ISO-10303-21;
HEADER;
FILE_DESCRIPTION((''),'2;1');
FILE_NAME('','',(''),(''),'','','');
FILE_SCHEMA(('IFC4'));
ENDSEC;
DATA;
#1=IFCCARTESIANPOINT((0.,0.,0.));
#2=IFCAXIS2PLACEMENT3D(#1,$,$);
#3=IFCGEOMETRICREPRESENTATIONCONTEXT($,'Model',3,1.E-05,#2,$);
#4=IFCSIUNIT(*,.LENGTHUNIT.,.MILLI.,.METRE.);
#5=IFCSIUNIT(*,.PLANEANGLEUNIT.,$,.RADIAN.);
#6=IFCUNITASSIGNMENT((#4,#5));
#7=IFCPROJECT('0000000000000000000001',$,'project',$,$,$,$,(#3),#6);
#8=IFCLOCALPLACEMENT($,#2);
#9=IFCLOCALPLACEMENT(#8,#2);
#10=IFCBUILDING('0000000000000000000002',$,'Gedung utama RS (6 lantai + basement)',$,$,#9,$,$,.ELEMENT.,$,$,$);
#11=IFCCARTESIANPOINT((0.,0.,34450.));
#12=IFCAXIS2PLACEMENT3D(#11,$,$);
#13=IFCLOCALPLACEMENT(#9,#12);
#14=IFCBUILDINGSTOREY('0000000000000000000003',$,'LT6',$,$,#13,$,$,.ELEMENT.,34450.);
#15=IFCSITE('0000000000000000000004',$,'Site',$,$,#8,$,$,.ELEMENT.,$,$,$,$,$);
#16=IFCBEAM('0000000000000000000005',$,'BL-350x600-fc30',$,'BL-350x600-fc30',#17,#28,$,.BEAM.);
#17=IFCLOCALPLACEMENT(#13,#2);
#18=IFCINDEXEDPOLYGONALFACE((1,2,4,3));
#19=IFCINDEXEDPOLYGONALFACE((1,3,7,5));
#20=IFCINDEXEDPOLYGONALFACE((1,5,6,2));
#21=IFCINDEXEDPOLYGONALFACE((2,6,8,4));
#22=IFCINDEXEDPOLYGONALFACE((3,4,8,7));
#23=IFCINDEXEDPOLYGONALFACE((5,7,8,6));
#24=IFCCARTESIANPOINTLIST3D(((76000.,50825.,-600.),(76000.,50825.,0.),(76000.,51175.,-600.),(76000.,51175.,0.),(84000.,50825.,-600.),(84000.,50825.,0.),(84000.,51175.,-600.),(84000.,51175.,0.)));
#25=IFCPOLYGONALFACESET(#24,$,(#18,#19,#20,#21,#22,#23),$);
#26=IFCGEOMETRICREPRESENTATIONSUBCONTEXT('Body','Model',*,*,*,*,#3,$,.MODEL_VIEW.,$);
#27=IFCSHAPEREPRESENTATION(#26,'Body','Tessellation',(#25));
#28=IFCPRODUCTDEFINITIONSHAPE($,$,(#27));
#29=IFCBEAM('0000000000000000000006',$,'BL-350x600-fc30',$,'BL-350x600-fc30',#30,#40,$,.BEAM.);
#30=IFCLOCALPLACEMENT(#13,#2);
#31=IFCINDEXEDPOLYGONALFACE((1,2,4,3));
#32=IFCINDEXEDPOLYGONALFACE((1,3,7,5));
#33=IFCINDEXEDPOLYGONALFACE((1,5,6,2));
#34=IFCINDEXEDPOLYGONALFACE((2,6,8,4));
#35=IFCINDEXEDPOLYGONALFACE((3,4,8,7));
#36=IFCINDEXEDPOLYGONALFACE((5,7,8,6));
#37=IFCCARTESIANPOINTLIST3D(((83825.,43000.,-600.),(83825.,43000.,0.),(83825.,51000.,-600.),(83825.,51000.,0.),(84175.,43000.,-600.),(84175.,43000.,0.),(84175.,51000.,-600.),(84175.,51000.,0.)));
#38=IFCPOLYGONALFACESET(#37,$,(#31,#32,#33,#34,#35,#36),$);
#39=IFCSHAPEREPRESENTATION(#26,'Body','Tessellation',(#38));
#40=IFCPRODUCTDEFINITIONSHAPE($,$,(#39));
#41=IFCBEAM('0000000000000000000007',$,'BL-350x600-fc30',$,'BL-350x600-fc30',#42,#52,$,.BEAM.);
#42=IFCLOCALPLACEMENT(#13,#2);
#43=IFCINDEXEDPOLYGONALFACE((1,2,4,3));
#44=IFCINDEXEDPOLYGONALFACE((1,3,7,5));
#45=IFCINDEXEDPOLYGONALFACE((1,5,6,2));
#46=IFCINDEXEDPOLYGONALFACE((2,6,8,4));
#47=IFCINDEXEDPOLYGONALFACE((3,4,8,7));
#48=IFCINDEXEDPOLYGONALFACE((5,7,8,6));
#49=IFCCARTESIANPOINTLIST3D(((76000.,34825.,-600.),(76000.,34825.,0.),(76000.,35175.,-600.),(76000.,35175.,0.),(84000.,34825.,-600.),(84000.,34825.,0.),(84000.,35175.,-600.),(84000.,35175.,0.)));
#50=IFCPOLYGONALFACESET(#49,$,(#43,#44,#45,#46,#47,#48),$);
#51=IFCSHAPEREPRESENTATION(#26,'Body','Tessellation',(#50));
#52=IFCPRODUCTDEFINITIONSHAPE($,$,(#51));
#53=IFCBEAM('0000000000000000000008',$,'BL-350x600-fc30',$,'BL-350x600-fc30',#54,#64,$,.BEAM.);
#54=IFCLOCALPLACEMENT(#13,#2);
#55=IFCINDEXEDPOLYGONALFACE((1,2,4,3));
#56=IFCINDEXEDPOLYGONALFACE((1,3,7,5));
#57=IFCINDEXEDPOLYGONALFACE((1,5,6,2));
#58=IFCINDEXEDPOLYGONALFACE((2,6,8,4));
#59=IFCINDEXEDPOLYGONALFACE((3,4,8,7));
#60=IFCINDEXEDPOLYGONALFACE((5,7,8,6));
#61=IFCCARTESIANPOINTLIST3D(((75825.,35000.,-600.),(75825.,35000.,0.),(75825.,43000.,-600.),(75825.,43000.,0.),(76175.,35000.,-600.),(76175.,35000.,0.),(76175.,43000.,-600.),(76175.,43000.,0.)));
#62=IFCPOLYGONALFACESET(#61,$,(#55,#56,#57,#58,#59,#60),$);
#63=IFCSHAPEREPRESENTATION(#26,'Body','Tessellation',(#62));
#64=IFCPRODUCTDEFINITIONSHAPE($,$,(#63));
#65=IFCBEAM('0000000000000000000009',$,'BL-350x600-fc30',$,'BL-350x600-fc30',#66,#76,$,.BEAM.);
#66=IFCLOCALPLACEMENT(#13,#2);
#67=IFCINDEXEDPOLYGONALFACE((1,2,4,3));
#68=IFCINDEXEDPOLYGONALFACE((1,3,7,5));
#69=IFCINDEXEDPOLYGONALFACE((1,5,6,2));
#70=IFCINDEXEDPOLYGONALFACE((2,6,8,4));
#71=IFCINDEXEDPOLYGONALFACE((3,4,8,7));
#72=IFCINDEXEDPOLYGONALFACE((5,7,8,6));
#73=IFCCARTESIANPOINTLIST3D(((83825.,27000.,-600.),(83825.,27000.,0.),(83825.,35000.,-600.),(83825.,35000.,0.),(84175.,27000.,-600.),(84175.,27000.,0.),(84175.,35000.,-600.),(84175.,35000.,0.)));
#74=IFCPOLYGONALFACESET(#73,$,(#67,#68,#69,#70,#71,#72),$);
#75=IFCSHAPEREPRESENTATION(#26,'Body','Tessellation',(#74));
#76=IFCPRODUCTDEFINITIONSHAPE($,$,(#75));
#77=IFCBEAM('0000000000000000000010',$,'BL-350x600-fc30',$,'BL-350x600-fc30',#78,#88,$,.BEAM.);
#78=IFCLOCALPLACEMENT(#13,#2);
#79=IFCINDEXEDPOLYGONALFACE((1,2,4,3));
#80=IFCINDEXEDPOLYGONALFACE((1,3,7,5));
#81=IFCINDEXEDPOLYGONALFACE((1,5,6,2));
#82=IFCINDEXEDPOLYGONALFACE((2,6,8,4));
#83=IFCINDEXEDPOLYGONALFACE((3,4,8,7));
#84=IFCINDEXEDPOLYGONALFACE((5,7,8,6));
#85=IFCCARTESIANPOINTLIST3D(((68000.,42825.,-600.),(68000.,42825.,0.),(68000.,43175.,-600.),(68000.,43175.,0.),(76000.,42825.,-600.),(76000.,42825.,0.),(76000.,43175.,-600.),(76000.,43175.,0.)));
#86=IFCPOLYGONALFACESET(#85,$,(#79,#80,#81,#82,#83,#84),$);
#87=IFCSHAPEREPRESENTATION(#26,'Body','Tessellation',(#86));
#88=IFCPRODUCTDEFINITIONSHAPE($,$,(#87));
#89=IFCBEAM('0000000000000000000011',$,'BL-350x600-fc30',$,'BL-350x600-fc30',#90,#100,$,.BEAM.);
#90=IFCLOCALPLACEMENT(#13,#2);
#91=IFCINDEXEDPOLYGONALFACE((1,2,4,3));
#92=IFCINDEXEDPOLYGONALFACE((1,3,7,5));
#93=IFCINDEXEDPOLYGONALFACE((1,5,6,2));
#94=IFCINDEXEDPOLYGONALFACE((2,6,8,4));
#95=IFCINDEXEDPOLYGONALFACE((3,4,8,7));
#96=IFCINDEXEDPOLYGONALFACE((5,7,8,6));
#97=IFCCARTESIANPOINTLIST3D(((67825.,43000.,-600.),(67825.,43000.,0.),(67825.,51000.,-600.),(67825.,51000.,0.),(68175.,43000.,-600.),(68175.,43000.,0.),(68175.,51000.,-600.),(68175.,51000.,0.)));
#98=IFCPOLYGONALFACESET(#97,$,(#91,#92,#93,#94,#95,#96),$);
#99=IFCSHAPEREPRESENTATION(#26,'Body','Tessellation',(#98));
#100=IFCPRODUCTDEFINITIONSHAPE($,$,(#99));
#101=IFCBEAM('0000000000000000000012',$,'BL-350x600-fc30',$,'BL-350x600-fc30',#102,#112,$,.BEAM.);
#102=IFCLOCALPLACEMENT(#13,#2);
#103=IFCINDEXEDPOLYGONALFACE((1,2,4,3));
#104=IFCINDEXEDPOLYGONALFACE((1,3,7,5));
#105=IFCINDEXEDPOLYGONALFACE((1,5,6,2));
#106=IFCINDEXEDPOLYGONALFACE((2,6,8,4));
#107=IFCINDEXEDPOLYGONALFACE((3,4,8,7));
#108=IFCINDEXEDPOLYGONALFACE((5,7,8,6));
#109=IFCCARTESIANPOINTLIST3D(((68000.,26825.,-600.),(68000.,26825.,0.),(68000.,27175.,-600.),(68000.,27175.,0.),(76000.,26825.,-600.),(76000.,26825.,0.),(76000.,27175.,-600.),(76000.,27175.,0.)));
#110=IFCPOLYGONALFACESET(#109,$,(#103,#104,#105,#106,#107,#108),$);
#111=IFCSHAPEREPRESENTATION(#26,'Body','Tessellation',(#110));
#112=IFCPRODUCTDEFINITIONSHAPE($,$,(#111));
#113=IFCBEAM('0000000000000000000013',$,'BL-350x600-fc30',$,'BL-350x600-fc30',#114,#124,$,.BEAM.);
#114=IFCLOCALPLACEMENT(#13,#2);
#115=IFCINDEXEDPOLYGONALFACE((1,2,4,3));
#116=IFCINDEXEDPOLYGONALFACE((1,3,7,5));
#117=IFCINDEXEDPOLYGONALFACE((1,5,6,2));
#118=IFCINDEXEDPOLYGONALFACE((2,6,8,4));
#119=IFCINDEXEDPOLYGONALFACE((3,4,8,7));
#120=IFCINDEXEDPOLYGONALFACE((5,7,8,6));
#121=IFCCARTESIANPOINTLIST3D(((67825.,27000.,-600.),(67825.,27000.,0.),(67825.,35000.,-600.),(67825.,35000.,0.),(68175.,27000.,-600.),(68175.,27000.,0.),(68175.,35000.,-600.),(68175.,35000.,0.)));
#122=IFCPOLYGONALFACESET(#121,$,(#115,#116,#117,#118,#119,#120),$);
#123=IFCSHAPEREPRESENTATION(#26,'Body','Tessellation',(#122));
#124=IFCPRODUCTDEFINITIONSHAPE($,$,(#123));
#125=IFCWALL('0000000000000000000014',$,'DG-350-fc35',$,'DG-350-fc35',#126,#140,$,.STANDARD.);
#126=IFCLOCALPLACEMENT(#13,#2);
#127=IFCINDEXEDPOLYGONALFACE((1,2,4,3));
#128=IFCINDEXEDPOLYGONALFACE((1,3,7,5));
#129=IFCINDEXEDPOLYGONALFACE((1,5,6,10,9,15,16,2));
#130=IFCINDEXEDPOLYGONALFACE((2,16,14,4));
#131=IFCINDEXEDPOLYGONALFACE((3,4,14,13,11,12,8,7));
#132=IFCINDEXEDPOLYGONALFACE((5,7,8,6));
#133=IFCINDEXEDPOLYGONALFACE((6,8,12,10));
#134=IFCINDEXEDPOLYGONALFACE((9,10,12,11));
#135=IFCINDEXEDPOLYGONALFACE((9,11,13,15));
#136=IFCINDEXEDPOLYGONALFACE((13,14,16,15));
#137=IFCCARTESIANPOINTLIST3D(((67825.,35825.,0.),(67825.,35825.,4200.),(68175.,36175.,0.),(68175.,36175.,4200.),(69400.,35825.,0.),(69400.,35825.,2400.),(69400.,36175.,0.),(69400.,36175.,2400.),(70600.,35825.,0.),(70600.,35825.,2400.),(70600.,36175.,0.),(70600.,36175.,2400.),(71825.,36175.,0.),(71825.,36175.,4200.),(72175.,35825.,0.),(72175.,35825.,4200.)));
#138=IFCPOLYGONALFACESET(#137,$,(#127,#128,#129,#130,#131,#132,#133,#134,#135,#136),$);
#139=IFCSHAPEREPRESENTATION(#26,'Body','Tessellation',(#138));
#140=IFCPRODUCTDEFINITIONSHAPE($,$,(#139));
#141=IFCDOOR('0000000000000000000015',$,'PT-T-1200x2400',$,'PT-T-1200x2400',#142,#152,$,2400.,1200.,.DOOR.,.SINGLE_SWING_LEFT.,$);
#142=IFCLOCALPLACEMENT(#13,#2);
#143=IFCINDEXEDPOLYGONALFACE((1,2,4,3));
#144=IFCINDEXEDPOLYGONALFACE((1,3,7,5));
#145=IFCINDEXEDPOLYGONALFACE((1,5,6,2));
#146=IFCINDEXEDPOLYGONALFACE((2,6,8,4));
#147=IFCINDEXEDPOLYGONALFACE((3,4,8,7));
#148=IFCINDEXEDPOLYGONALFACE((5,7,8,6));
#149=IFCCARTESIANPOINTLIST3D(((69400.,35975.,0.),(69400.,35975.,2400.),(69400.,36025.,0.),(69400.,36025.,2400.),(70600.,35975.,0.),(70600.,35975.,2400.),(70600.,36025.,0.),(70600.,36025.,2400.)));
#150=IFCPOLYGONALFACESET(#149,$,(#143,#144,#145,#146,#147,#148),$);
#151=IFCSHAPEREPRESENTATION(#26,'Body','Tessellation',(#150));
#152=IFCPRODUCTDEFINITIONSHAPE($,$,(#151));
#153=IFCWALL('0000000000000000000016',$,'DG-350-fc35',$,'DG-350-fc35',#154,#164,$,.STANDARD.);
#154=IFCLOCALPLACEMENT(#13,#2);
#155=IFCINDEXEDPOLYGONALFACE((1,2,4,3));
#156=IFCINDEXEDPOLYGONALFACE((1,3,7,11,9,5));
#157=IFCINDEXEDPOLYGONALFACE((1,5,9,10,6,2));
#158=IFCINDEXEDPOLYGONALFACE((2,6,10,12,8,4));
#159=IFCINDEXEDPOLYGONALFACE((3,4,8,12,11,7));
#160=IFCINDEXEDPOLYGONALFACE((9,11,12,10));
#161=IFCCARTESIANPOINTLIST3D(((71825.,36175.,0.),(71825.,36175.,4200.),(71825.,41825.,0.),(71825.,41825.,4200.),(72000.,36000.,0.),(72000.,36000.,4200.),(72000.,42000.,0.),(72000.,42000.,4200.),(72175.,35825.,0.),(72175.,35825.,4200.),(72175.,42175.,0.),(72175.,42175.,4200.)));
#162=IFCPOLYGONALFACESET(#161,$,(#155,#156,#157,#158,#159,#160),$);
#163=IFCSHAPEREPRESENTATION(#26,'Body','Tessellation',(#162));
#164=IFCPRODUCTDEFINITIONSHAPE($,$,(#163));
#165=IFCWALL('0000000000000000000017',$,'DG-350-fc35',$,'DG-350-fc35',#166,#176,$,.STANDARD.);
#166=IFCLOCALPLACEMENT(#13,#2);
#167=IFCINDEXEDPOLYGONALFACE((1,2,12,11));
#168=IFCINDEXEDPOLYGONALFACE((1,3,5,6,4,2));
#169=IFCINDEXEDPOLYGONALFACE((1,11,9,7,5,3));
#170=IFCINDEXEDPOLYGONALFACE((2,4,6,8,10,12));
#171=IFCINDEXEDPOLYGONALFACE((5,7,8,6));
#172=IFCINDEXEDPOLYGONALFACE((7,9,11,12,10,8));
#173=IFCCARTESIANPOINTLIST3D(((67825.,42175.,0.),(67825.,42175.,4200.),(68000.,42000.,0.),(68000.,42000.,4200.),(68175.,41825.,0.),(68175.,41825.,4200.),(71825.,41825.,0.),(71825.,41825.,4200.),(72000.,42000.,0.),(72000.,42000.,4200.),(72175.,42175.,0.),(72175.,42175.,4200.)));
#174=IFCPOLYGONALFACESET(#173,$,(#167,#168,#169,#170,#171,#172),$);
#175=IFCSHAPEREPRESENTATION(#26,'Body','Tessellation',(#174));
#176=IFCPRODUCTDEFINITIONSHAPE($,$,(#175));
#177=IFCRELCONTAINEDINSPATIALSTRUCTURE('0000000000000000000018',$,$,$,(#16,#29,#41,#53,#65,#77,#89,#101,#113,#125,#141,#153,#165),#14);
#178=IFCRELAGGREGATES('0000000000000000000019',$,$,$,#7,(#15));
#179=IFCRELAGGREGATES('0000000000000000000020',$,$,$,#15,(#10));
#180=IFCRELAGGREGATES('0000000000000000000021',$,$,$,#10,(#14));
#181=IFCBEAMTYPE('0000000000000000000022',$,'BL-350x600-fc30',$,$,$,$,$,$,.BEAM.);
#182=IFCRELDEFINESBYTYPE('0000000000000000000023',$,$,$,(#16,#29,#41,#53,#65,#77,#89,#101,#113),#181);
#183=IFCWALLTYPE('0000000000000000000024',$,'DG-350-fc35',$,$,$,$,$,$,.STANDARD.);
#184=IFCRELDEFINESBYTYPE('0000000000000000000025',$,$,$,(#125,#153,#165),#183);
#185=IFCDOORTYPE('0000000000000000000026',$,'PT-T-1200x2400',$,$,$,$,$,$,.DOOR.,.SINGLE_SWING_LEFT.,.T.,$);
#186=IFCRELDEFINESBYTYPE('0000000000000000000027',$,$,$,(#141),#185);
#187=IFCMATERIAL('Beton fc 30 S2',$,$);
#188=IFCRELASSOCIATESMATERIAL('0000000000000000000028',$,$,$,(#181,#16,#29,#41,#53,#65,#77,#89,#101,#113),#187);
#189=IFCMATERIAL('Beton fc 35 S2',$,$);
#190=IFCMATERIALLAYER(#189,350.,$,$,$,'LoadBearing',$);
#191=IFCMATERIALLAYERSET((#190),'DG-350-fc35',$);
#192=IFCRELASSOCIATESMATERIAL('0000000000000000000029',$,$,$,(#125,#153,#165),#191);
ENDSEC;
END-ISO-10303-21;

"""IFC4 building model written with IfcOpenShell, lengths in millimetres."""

from ifc_helpers import new_model, si_unit, frame, frame_2d, origin, origin_2d, place, context, subcontext, project, spatial, polyline, rectangle, outline, extrude, material, layer, layer_set, layer_usage, material_profile, profile_set, profile_usage, type_object, element, fill, save


model = new_model("IFC4")

# Units and contexts
model_context = context("Model", 3, precision=1e-05, world=origin())
body_context = subcontext(model_context, "Body", "Model", "MODEL_VIEW")
ifc_project = project(units=[si_unit("LENGTHUNIT", "METRE", prefix="MILLI"), si_unit("PLANEANGLEUNIT", "RADIAN")], contexts=[model_context])

# Site, building, storey
site_placement = place(None, origin())
site = spatial("IfcSite", under=ifc_project, at=site_placement, Name="Site", CompositionType="ELEMENT")
building_placement = place(site_placement, origin())
building = spatial("IfcBuilding", under=site, at=building_placement, Name="Gedung utama RS (6 lantai + basement)", CompositionType="ELEMENT")
storey_placement = place(building_placement, frame((0.0, 0.0, 34450.0)))
storey = spatial("IfcBuildingStorey", under=building, at=storey_placement, Name="LT6", CompositionType="ELEMENT", Elevation=34450.0)

# Beams
ifc_material_1 = material(Name="Beton fc 30 S2")
ifc_material_profile_1 = material_profile(ifc_material_1, rectangle(XDim=350.0, YDim=600.0, at=origin_2d()), Name="BL-350x600-fc30")
ifc_profile_set_1 = profile_set([ifc_material_profile_1], Name="BL-350x600-fc30")
ifc_profile_usage_1 = profile_usage(ifc_profile_set_1, cardinal=8)
beam_type = type_object("IfcBeamType", Name="BL-350x600-fc30", PredefinedType="BEAM", material=ifc_profile_set_1)
beam_1_placement = place(storey_placement, frame((76000.0, 51000.0, -300.0)))
element("IfcBeam", 1, at=beam_1_placement, inside=storey, type_object=beam_type, material=ifc_profile_usage_1, Name="BL-350x600-fc30", ObjectType="BL-350x600-fc30", PredefinedType="BEAM", context=body_context, shape_type="SweptSolid", body=[
    extrude(rectangle(XDim=350.0, YDim=600.0, at=origin_2d()), frame((0.0, 0.0, 0.0), z_axis=(1.0, 0.0, 0.0), x_axis=(0.0, 1.0, 0.0)), (0.0, 0.0, 1.0), 8000.0),
])
beam_2_placement = place(storey_placement, frame((84000.0, 43000.0, -300.0)))
element("IfcBeam", 2, at=beam_2_placement, inside=storey, type_object=beam_type, material=ifc_profile_usage_1, Name="BL-350x600-fc30", ObjectType="BL-350x600-fc30", PredefinedType="BEAM", context=body_context, shape_type="SweptSolid", body=[
    extrude(rectangle(XDim=350.0, YDim=600.0, at=origin_2d()), frame((0.0, 0.0, 0.0), z_axis=(0.0, 1.0, 0.0), x_axis=(-1.0, 0.0, 0.0)), (0.0, 0.0, 1.0), 8000.0),
])
beam_3_placement = place(storey_placement, frame((76000.0, 35000.0, -300.0)))
element("IfcBeam", 3, at=beam_3_placement, inside=storey, type_object=beam_type, material=ifc_profile_usage_1, Name="BL-350x600-fc30", ObjectType="BL-350x600-fc30", PredefinedType="BEAM", context=body_context, shape_type="SweptSolid", body=[
    extrude(rectangle(XDim=350.0, YDim=600.0, at=origin_2d()), frame((0.0, 0.0, 0.0), z_axis=(1.0, 0.0, 0.0), x_axis=(0.0, 1.0, 0.0)), (0.0, 0.0, 1.0), 8000.0),
])
for number, where, name in (
    (4, (76000.0, 35000.0, -300.0), "BL-350x600-fc30"),
    (5, (84000.0, 27000.0, -300.0), "BL-350x600-fc30"),
):
    element("IfcBeam", number, at=place(storey_placement, frame(where)), inside=storey, type_object=beam_type, material=ifc_profile_usage_1, Name=name, ObjectType="BL-350x600-fc30", PredefinedType="BEAM", context=body_context, shape_type="SweptSolid", body=[
        extrude(rectangle(XDim=350.0, YDim=600.0, at=origin_2d()), frame((0.0, 0.0, 0.0), z_axis=(0.0, 1.0, 0.0), x_axis=(-1.0, 0.0, 0.0)), (0.0, 0.0, 1.0), 8000.0),
    ])
beam_4_placement = place(storey_placement, frame((68000.0, 43000.0, -300.0)))
element("IfcBeam", 6, at=beam_4_placement, inside=storey, type_object=beam_type, material=ifc_profile_usage_1, Name="BL-350x600-fc30", ObjectType="BL-350x600-fc30", PredefinedType="BEAM", context=body_context, shape_type="SweptSolid", body=[
    extrude(rectangle(XDim=350.0, YDim=600.0, at=origin_2d()), frame((0.0, 0.0, 0.0), z_axis=(1.0, 0.0, 0.0), x_axis=(0.0, 1.0, 0.0)), (0.0, 0.0, 1.0), 8000.0),
])
beam_5_placement = place(storey_placement, frame((68000.0, 43000.0, -300.0)))
element("IfcBeam", 7, at=beam_5_placement, inside=storey, type_object=beam_type, material=ifc_profile_usage_1, Name="BL-350x600-fc30", ObjectType="BL-350x600-fc30", PredefinedType="BEAM", context=body_context, shape_type="SweptSolid", body=[
    extrude(rectangle(XDim=350.0, YDim=600.0, at=origin_2d()), frame((0.0, 0.0, 0.0), z_axis=(0.0, 1.0, 0.0), x_axis=(-1.0, 0.0, 0.0)), (0.0, 0.0, 1.0), 8000.0),
])
beam_6_placement = place(storey_placement, frame((68000.0, 27000.0, -300.0)))
element("IfcBeam", 8, at=beam_6_placement, inside=storey, type_object=beam_type, material=ifc_profile_usage_1, Name="BL-350x600-fc30", ObjectType="BL-350x600-fc30", PredefinedType="BEAM", context=body_context, shape_type="SweptSolid", body=[
    extrude(rectangle(XDim=350.0, YDim=600.0, at=origin_2d()), frame((0.0, 0.0, 0.0), z_axis=(1.0, 0.0, 0.0), x_axis=(0.0, 1.0, 0.0)), (0.0, 0.0, 1.0), 8000.0),
])
beam_7_placement = place(storey_placement, frame((68000.0, 27000.0, -300.0)))
element("IfcBeam", 9, at=beam_7_placement, inside=storey, type_object=beam_type, material=ifc_profile_usage_1, Name="BL-350x600-fc30", ObjectType="BL-350x600-fc30", PredefinedType="BEAM", context=body_context, shape_type="SweptSolid", body=[
    extrude(rectangle(XDim=350.0, YDim=600.0, at=origin_2d()), frame((0.0, 0.0, 0.0), z_axis=(0.0, 1.0, 0.0), x_axis=(-1.0, 0.0, 0.0)), (0.0, 0.0, 1.0), 8000.0),
])

# Wall, opening, door
ifc_material_2 = material(Name="Beton fc 35 S2")
ifc_layer = layer(ifc_material_2, 350.0, Category="LoadBearing")
ifc_layer_set = layer_set([ifc_layer], Name="DG-350-fc35")
ifc_layer_usage = layer_usage(ifc_layer_set, "AXIS2", "NEGATIVE", 175.0)
wall_type = type_object("IfcWallType", Name="DG-350-fc35", PredefinedType="STANDARD")
wall_1_placement = place(storey_placement, frame((68000.0, 36000.0, 0.0), z_axis=(0.0, 0.0, 1.0), x_axis=(1.0, 0.0, 0.0)))
wall_1 = element("IfcWall", 10, at=wall_1_placement, inside=storey, type_object=wall_type, material=ifc_layer_usage, Name="DG-350-fc35", ObjectType="DG-350-fc35", PredefinedType="STANDARD", context=body_context, shape_type="SweptSolid", body=[
    extrude(outline(polyline([(-175.0, -175.0), (0.0, 0.0), (175.0, 175.0), (3825.0, 175.0), (4000.0, 0.0), (4175.0, -175.0), (-175.0, -175.0)])), origin(), (0.0, 0.0, 1.0), 4200.0),
])
opening_placement = place(wall_1_placement, frame((1400.0, 0.0, 0.0), z_axis=(0.0, 0.0, 1.0), x_axis=(1.0, 0.0, 0.0)))
opening = element("IfcOpeningElement", 11, at=opening_placement, cuts=wall_1, PredefinedType="OPENING", context=body_context, shape_type="SweptSolid", body=[
    extrude(rectangle(XDim=1200.0, YDim=370.0, at=frame_2d((600.0, 0.0))), origin(), (0.0, 0.0, 1.0), 2400.0),
])
door_type = type_object("IfcDoorType", Name="PT-T-1200x2400", OperationType="SINGLE_SWING_LEFT", ParameterTakesPrecedence=True, PredefinedType="DOOR")
door_placement = place(opening_placement, origin())
door = element("IfcDoor", 12, at=door_placement, inside=storey, type_object=door_type, Name="PT-T-1200x2400", ObjectType="PT-T-1200x2400", OperationType="SINGLE_SWING_LEFT", OverallHeight=2400.0, OverallWidth=1200.0, PredefinedType="DOOR", context=body_context, shape_type="SweptSolid", body=[
    extrude(rectangle(XDim=1200.0, YDim=50.0, at=frame_2d((600.0, 0.0))), origin(), (0.0, 0.0, 1.0), 2400.0),
])
fill(opening, door)

# Walls
wall_2_placement = place(storey_placement, frame((72000.0, 36000.0, 0.0), z_axis=(0.0, 0.0, 1.0), x_axis=(0.0, 1.0, 0.0)))
element("IfcWall", 13, at=wall_2_placement, inside=storey, type_object=wall_type, material=ifc_layer_usage, Name="DG-350-fc35", ObjectType="DG-350-fc35", PredefinedType="STANDARD", context=body_context, shape_type="SweptSolid", body=[
    extrude(outline(polyline([(-175.0, -175.0), (0.0, 0.0), (175.0, 175.0), (5825.0, 175.0), (6000.0, 0.0), (6175.0, -175.0), (-175.0, -175.0)])), origin(), (0.0, 0.0, 1.0), 4200.0),
])
wall_3_placement = place(storey_placement, frame((72000.0, 42000.0, 0.0), z_axis=(0.0, 0.0, 1.0), x_axis=(-1.0, 0.0, 0.0)))
element("IfcWall", 14, at=wall_3_placement, inside=storey, type_object=wall_type, material=ifc_layer_usage, Name="DG-350-fc35", ObjectType="DG-350-fc35", PredefinedType="STANDARD", context=body_context, shape_type="SweptSolid", body=[
    extrude(outline(polyline([(-175.0, -175.0), (0.0, 0.0), (175.0, 175.0), (3825.0, 175.0), (4000.0, 0.0), (4175.0, -175.0), (-175.0, -175.0)])), origin(), (0.0, 0.0, 1.0), 4200.0),
])

save(model, "model.ifc")
